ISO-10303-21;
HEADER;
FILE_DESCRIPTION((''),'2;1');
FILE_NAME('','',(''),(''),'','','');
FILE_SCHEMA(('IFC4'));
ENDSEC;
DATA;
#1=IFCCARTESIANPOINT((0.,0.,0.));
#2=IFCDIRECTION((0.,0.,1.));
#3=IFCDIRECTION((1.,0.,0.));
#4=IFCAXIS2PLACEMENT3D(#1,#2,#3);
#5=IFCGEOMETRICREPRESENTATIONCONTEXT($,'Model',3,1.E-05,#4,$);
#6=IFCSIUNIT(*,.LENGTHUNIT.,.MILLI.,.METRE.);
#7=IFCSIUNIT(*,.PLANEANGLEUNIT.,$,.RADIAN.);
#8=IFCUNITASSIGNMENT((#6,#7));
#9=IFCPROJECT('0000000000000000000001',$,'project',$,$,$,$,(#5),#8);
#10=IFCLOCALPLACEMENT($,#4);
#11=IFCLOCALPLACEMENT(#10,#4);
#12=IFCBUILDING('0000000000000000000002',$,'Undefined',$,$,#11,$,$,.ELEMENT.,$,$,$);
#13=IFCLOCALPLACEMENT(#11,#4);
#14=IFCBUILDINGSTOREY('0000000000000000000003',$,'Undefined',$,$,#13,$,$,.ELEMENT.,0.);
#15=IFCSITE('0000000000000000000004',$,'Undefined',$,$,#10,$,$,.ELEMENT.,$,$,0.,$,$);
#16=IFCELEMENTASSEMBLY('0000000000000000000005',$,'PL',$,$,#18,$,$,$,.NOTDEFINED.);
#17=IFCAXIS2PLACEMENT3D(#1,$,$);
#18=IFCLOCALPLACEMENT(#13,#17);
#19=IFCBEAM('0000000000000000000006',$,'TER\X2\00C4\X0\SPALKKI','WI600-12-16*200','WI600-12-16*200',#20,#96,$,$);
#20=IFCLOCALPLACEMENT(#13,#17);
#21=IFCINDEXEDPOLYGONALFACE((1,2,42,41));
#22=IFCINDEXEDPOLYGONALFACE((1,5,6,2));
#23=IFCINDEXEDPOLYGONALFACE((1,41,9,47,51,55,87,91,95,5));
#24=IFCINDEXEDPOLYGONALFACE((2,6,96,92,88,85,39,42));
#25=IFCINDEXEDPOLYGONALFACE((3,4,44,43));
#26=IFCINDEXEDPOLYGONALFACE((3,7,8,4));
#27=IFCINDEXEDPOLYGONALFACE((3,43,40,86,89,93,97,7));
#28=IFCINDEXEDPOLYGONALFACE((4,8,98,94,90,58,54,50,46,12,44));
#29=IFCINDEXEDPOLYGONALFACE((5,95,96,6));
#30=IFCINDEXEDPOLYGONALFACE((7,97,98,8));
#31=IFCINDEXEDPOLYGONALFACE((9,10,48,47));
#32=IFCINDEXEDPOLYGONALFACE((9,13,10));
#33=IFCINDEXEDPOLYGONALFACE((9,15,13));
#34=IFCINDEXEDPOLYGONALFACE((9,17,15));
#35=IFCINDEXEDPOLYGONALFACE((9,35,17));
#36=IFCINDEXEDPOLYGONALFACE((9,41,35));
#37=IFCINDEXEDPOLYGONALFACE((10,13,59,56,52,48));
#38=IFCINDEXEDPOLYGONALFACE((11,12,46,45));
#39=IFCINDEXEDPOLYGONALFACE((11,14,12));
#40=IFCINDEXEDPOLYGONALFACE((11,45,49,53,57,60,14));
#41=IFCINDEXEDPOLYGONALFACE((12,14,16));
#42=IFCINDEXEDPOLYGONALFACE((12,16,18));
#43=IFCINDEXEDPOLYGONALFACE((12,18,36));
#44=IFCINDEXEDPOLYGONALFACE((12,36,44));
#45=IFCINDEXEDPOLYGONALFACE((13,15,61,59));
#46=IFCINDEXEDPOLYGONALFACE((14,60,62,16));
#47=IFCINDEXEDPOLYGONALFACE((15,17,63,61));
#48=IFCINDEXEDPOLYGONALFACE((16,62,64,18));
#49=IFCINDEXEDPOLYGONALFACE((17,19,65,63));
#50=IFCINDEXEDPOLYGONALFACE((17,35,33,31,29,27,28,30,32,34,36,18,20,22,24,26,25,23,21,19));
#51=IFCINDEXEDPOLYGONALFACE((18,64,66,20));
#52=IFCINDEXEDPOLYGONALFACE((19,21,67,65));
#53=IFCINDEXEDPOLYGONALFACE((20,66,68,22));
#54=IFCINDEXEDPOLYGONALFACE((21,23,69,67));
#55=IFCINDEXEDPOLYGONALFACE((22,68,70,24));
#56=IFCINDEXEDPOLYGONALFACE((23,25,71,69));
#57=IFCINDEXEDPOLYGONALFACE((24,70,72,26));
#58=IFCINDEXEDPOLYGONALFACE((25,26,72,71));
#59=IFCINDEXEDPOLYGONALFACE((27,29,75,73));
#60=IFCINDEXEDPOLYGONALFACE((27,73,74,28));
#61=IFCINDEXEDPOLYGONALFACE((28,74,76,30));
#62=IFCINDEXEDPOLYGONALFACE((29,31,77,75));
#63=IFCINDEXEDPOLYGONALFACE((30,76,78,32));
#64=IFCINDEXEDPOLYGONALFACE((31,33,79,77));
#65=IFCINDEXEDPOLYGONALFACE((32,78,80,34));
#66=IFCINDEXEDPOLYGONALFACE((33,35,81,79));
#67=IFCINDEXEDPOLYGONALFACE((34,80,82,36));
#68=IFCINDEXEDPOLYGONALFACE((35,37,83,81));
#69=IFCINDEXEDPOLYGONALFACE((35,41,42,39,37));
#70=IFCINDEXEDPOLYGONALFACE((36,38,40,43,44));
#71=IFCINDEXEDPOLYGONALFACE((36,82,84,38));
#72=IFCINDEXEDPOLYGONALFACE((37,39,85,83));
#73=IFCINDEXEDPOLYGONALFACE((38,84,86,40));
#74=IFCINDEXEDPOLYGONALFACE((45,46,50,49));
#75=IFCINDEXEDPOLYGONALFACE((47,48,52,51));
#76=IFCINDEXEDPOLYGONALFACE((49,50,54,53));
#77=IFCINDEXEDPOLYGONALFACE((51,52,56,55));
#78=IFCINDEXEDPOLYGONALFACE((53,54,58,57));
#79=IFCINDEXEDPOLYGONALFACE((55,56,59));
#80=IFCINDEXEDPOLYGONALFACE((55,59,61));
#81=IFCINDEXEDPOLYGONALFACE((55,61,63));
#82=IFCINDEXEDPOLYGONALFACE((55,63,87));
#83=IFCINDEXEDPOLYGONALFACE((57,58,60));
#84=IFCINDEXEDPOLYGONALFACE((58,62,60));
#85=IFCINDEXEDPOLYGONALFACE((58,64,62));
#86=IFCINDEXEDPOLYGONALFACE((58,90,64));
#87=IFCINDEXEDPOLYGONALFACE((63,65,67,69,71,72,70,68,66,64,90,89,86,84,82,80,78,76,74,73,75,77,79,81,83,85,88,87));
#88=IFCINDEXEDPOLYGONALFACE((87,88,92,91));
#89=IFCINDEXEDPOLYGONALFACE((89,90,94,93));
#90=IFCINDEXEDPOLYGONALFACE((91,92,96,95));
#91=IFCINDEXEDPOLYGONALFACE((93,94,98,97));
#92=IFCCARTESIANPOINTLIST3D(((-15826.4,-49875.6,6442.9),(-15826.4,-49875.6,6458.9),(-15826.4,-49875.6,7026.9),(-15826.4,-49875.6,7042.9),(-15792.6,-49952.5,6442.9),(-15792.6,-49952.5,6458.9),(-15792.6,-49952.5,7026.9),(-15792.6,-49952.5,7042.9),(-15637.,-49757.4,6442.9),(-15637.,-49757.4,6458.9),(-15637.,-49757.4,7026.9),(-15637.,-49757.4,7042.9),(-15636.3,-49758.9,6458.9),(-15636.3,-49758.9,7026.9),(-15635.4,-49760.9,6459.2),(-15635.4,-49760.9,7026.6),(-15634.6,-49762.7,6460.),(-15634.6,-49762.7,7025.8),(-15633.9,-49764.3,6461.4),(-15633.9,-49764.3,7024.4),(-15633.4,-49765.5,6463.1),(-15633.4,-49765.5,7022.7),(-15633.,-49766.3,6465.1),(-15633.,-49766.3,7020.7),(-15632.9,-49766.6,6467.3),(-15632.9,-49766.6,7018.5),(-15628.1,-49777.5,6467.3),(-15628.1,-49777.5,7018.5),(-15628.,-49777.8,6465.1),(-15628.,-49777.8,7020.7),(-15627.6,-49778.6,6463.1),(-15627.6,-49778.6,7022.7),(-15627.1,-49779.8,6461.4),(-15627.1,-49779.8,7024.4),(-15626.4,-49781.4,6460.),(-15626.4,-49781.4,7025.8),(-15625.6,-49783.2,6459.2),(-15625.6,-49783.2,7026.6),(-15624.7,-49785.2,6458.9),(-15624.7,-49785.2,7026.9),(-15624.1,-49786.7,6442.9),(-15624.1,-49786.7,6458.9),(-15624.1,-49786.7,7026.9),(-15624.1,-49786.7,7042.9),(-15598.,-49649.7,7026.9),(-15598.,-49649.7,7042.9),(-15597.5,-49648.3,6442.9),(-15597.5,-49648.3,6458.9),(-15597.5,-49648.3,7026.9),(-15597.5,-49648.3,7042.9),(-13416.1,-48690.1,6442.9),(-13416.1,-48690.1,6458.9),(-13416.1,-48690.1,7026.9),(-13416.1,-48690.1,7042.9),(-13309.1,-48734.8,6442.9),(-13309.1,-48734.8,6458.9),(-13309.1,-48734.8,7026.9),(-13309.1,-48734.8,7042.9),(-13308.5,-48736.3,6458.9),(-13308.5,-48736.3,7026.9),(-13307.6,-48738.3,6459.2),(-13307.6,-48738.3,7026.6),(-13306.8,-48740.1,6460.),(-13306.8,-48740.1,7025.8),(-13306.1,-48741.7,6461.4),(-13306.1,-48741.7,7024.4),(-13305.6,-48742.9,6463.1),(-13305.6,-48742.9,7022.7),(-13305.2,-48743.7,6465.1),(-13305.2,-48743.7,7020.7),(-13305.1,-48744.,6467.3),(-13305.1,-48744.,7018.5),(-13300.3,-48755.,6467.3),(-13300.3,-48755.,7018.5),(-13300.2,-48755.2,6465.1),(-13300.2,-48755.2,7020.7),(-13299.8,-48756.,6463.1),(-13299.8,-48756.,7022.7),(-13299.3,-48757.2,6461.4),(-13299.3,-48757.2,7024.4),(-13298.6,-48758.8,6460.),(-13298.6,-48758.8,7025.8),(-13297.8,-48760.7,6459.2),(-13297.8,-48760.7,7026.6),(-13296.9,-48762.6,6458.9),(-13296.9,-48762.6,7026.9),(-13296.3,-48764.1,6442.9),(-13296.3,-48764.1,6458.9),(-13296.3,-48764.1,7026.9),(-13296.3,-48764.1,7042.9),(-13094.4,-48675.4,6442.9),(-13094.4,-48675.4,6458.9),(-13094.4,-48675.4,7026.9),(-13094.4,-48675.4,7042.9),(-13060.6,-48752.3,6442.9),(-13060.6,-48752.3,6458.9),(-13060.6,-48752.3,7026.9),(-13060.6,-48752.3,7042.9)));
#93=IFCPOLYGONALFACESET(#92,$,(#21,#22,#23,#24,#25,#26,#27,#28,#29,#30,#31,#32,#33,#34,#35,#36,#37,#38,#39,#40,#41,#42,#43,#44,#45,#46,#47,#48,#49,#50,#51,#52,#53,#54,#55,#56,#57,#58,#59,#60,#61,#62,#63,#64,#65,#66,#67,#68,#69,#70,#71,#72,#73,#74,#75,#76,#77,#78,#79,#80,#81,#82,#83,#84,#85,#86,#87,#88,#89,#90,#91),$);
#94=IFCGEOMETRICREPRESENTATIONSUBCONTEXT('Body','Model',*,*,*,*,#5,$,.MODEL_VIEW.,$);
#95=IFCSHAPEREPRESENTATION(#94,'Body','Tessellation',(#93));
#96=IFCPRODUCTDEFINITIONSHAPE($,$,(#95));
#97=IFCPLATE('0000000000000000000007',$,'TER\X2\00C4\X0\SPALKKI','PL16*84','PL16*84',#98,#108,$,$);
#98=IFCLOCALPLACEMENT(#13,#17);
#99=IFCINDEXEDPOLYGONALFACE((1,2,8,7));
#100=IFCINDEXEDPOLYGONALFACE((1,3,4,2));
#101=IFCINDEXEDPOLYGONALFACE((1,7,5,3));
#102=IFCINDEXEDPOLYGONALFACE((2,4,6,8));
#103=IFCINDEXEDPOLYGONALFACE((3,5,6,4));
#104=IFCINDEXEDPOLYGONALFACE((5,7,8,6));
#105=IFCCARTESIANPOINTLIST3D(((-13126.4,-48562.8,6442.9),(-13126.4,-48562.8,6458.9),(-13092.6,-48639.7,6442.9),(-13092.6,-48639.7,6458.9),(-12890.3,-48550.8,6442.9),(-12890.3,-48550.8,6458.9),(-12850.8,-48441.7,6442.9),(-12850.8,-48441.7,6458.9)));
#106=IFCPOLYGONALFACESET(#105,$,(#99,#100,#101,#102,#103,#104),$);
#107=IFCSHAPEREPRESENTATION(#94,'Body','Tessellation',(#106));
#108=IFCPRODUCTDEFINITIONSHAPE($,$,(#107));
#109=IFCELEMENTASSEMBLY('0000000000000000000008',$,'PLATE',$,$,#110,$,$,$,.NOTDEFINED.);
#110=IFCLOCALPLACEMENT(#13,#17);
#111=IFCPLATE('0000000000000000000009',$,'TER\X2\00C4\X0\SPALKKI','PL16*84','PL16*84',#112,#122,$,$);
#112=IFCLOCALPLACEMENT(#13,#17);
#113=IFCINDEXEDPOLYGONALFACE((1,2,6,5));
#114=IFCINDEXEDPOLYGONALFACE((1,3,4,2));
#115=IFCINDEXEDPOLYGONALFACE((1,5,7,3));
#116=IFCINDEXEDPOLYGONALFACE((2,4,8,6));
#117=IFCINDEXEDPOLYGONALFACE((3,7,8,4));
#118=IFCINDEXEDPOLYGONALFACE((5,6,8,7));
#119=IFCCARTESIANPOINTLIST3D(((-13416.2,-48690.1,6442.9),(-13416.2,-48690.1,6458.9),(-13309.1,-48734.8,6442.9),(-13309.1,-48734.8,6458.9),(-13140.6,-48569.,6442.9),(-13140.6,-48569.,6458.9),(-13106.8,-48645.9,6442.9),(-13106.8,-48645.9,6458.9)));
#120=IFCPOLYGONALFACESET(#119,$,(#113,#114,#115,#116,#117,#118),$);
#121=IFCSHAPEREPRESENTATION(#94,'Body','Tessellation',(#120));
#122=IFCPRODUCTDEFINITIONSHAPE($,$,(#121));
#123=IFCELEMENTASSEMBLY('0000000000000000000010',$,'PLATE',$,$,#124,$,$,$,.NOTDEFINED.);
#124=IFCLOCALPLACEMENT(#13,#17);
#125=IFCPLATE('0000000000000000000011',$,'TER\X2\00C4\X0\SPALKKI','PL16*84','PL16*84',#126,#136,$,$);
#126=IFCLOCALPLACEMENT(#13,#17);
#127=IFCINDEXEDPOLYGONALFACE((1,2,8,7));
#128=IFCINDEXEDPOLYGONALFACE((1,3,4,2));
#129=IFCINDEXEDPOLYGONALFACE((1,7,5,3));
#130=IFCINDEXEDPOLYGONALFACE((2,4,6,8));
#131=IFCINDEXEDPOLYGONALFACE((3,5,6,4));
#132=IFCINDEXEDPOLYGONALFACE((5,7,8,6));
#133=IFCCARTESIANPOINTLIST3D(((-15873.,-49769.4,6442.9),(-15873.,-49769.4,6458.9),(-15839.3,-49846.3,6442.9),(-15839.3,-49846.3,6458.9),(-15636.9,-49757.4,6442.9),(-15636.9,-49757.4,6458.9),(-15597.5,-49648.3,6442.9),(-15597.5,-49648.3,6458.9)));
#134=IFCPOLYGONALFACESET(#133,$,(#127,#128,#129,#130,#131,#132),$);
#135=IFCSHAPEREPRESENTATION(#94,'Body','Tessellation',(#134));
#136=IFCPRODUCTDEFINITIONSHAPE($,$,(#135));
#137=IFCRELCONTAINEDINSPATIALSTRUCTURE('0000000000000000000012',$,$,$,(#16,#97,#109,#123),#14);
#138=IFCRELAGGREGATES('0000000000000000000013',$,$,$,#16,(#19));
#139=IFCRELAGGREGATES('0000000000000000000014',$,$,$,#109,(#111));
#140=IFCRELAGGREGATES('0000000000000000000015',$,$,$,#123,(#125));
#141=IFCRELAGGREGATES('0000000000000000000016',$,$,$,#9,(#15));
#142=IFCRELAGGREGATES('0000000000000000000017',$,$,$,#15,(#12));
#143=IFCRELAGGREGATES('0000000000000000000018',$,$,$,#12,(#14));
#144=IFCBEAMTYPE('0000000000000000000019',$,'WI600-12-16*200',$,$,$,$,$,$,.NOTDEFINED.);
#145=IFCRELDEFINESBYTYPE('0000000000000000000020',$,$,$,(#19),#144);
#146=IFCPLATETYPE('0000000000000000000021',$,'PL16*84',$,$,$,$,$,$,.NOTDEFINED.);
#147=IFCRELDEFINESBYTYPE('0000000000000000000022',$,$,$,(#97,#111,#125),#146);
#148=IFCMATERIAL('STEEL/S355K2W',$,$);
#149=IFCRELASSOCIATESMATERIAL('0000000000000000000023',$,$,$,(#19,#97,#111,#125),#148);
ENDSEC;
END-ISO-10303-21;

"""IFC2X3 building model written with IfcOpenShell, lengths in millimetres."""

from ifc_helpers import new_model, si_unit, frame, origin_with_axes, origin_2d_with_axis, place, context, subcontext, project, spatial, polyline, i_section, outline, extrude, material, type_object, element, aggregate, save


model = new_model("IFC2X3")

# Units and contexts
model_context = context("Model", 3, precision=1e-05, world=origin_with_axes())
body_context = subcontext(model_context, "Body", "Model", "MODEL_VIEW")
ifc_project = project(units=[si_unit("LENGTHUNIT", "METRE", prefix="MILLI"), si_unit("PLANEANGLEUNIT", "RADIAN")], contexts=[model_context])

# Site, building, storey
site_placement = place(None, origin_with_axes())
site = spatial("IfcSite", under=ifc_project, at=site_placement, Name="Undefined", CompositionType="ELEMENT", RefElevation=0.0)
building_placement = place(site_placement, origin_with_axes())
building = spatial("IfcBuilding", under=site, at=building_placement, Name="Undefined", CompositionType="ELEMENT")
storey_placement = place(building_placement, origin_with_axes())
storey = spatial("IfcBuildingStorey", under=building, at=storey_placement, Name="Undefined", CompositionType="ELEMENT", Elevation=0.0)

# Shared definitions
ifc_material_1 = material(Name="STEEL/S355K2W")
beam_type_1 = type_object("IfcBeamType", Name="WI600-12-16*200", PredefinedType="NOTDEFINED")

# Element assembly, beam, openings
assembly_1_placement = place(storey_placement, frame((-15832.8, -49860.9, 6742.9), z_axis=(0.0, 0.0, 1.0), x_axis=(0.915553, 0.402198, 0.0)))
assembly_1 = element("IfcElementAssembly", 1, at=assembly_1_placement, inside=storey, Name="PL", PredefinedType="NOTDEFINED")
beam_1_placement = place(storey_placement, frame((-15832.8, -49860.9, 6742.9), z_axis=(0.0, 0.0, 1.0), x_axis=(0.915553, 0.402198, 0.0)))
beam_1 = element("IfcBeam", 2, at=beam_1_placement, type_object=beam_type_1, material=ifc_material_1, Name="TERÄSPALKKI", Description="WI600-12-16*200", ObjectType="WI600-12-16*200", context=body_context, shape_type="SweptSolid", body=[
    extrude(i_section(OverallWidth=200.0, OverallDepth=600.0, WebThickness=12.0, FlangeThickness=16.0, FilletRadius=8.4, at=origin_2d_with_axis()), frame((2984.0, 0.0, 0.0), z_axis=(-1.0, 0.0, 0.0), x_axis=(0.0, -1.0, 0.0)), (0.0, 0.0, 1.0), 2984.0),
])
opening_1_placement = place(storey_placement, frame((-15832.8, -49860.9, 6742.9), z_axis=(0.0, 0.0, 1.0), x_axis=(0.915553, 0.402198, 0.0)))
element("IfcOpeningElement", 3, at=opening_1_placement, cuts=beam_1, ObjectType="Recess", context=body_context, shape_type="SweptSolid", body=[
    extrude(outline(polyline([(0.0, 0.0), (220.0, 0.0), (301.0, 85.0), (0.0, 85.0), (0.0, 0.0)])), frame((0.0, 15.0, 284.0), z_axis=(0.0, 0.0, 1.0), x_axis=(1.0, -0.000005, 0.0)), (0.0, 0.0, 1.0), 16.0),
])
opening_2_placement = place(storey_placement, frame((-15832.8, -49860.9, 6742.9), z_axis=(0.0, 0.0, 1.0), x_axis=(0.915553, 0.402198, 0.0)))
element("IfcOpeningElement", 4, at=opening_2_placement, cuts=beam_1, ObjectType="Recess", context=body_context, shape_type="SweptSolid", body=[
    extrude(outline(polyline([(0.0, 0.0), (32.0, 0.0), (32.0, 237.0), (0.0, 237.0), (0.0, 0.0)])), frame((-16.0, 16.0, -302.5), z_axis=(0.0, 0.0, 1.0), x_axis=(-0.000005, -1.0, 0.0)), (0.0, 0.0, 1.0), 605.0),
])
opening_3_placement = place(storey_placement, frame((-15832.8, -49860.9, 6742.9), z_axis=(0.0, 0.0, 1.0), x_axis=(0.915553, 0.402198, 0.0)))
element("IfcOpeningElement", 5, at=opening_3_placement, cuts=beam_1, ObjectType="Recess", context=body_context, shape_type="SweptSolid", body=[
    extrude(outline(polyline([(0.0, 0.0), (221.0, 0.0), (301.0, 84.0), (0.0, 84.0), (0.0, 0.0)])), frame((-1.0, 15.0, 284.0), z_axis=(0.0, 0.0, 1.0), x_axis=(1.0, -0.000005, 0.0)), (0.0, 0.0, 1.0), 16.0),
])
opening_4_placement = place(storey_placement, frame((-15832.8, -49860.9, 6742.9), z_axis=(0.0, 0.0, 1.0), x_axis=(0.915553, 0.402198, 0.0)))
element("IfcOpeningElement", 6, at=opening_4_placement, cuts=beam_1, ObjectType="Recess", context=body_context, shape_type="SweptSolid", body=[
    extrude(outline(polyline([(0.0, 0.0), (220.0, 0.0), (301.0, 85.0), (0.0, 85.0), (0.0, 0.0)])), frame((0.0, 15.0, -300.0), z_axis=(0.0, 0.0, 1.0), x_axis=(1.0, -0.000005, 0.0)), (0.0, 0.0, 1.0), 16.0),
])
opening_5_placement = place(storey_placement, frame((-15832.8, -49860.9, 6742.9), z_axis=(0.0, 0.0, 1.0), x_axis=(0.915553, 0.402198, 0.0)))
element("IfcOpeningElement", 7, at=opening_5_placement, cuts=beam_1, ObjectType="Recess", context=body_context, shape_type="SweptSolid", body=[
    extrude(outline(polyline([(0.0, 0.0), (32.0, 0.0), (32.0, 237.0), (0.0, 237.0), (0.0, 0.0)])), frame((3000.5, 16.0, 302.5), z_axis=(0.0, 0.0, -1.0), x_axis=(0.000004, -1.0, 0.0)), (0.0, 0.0, 1.0), 605.0),
])
opening_6_placement = place(storey_placement, frame((-15832.8, -49860.9, 6742.9), z_axis=(0.0, 0.0, 1.0), x_axis=(0.915553, 0.402198, 0.0)))
element("IfcOpeningElement", 8, at=opening_6_placement, cuts=beam_1, ObjectType="Recess", context=body_context, shape_type="SweptSolid", body=[
    extrude(outline(polyline([(0.0, 0.0), (220.0, 0.0), (301.0, 85.0), (0.0, 85.0), (0.0, 0.0)])), frame((2984.5, 15.0, -284.0), z_axis=(0.0, 0.0, -1.0), x_axis=(-1.0, -0.000004, 0.0)), (0.0, 0.0, 1.0), 16.0),
])
opening_7_placement = place(storey_placement, frame((-15832.8, -49860.9, 6742.9), z_axis=(0.0, 0.0, 1.0), x_axis=(0.915553, 0.402198, 0.0)))
element("IfcOpeningElement", 9, at=opening_7_placement, cuts=beam_1, ObjectType="Recess", context=body_context, shape_type="SweptSolid", body=[
    extrude(outline(polyline([(0.0, 0.0), (220.0, 0.0), (301.0, 85.0), (0.0, 85.0), (0.0, 0.0)])), frame((2984.5, 15.0, 300.0), z_axis=(0.0, 0.0, -1.0), x_axis=(-1.0, -0.000004, 0.0)), (0.0, 0.0, 1.0), 16.0),
])
aggregate(assembly_1, [beam_1])

# Plate
plate_type = type_object("IfcPlateType", Name="PL16*84", PredefinedType="NOTDEFINED")
plate_1_placement = place(storey_placement, frame((-13092.6, -48639.7, 6450.9), z_axis=(0.0, 0.0, 1.0), x_axis=(0.915555, 0.402194, 0.0)))
element("IfcPlate", 10, at=plate_1_placement, inside=storey, type_object=plate_type, material=ifc_material_1, Name="TERÄSPALKKI", Description="PL16*84", ObjectType="PL16*84", context=body_context, shape_type="SweptSolid", body=[
    extrude(outline(polyline([(0.0, 0.0), (221.0, 0.0), (301.0, 84.0), (0.0, 84.0), (0.0, 0.0)])), frame((0.0, 0.0, -8.0), z_axis=(0.0, 0.0, 1.0), x_axis=(1.0, 0.0, 0.0)), (0.0, 0.0, 1.0), 16.0),
])

# Element assemblies, plates
assembly_2_placement = place(storey_placement, frame((-13106.8, -48645.9, 6450.9), z_axis=(-0.402202, 0.915551, 0.0), x_axis=(-0.915551, -0.402202, 0.0)))
assembly_2 = element("IfcElementAssembly", 11, at=assembly_2_placement, inside=storey, Name="PLATE", PredefinedType="NOTDEFINED")
plate_2_placement = place(storey_placement, frame((-13106.8, -48645.9, 6450.9), z_axis=(0.0, 0.0, -1.0), x_axis=(-0.915551, -0.402202, 0.0)))
plate_2 = element("IfcPlate", 12, at=plate_2_placement, type_object=plate_type, material=ifc_material_1, Name="TERÄSPALKKI", Description="PL16*84", ObjectType="PL16*84", context=body_context, shape_type="SweptSolid", body=[
    extrude(outline(polyline([(0.0, 0.0), (221.0, 0.0), (301.0, 84.0), (0.0, 84.0), (0.0, 0.0)])), frame((0.0, 0.0, -8.0), z_axis=(0.0, 0.0, 1.0), x_axis=(1.0, 0.0, 0.0)), (0.0, 0.0, 1.0), 16.0),
])
aggregate(assembly_2, [plate_2])
assembly_3_placement = place(storey_placement, frame((-15839.3, -49846.3, 6450.9), z_axis=(-0.402193, 0.915555, 0.0), x_axis=(0.915555, 0.402194, 0.0)))
assembly_3 = element("IfcElementAssembly", 13, at=assembly_3_placement, inside=storey, Name="PLATE", PredefinedType="NOTDEFINED")
plate_3_placement = place(storey_placement, frame((-15839.3, -49846.3, 6450.9), z_axis=(0.0, 0.0, 1.0), x_axis=(0.915555, 0.402194, 0.0)))
plate_3 = element("IfcPlate", 14, at=plate_3_placement, type_object=plate_type, material=ifc_material_1, Name="TERÄSPALKKI", Description="PL16*84", ObjectType="PL16*84", context=body_context, shape_type="SweptSolid", body=[
    extrude(outline(polyline([(0.0, 0.0), (221.0, 0.0), (301.0, 84.0), (0.0, 84.0), (0.0, 0.0)])), frame((0.0, 0.0, -8.0), z_axis=(0.0, 0.0, 1.0), x_axis=(1.0, 0.0, 0.0)), (0.0, 0.0, 1.0), 16.0),
])
aggregate(assembly_3, [plate_3])

save(model, "model.ifc")
